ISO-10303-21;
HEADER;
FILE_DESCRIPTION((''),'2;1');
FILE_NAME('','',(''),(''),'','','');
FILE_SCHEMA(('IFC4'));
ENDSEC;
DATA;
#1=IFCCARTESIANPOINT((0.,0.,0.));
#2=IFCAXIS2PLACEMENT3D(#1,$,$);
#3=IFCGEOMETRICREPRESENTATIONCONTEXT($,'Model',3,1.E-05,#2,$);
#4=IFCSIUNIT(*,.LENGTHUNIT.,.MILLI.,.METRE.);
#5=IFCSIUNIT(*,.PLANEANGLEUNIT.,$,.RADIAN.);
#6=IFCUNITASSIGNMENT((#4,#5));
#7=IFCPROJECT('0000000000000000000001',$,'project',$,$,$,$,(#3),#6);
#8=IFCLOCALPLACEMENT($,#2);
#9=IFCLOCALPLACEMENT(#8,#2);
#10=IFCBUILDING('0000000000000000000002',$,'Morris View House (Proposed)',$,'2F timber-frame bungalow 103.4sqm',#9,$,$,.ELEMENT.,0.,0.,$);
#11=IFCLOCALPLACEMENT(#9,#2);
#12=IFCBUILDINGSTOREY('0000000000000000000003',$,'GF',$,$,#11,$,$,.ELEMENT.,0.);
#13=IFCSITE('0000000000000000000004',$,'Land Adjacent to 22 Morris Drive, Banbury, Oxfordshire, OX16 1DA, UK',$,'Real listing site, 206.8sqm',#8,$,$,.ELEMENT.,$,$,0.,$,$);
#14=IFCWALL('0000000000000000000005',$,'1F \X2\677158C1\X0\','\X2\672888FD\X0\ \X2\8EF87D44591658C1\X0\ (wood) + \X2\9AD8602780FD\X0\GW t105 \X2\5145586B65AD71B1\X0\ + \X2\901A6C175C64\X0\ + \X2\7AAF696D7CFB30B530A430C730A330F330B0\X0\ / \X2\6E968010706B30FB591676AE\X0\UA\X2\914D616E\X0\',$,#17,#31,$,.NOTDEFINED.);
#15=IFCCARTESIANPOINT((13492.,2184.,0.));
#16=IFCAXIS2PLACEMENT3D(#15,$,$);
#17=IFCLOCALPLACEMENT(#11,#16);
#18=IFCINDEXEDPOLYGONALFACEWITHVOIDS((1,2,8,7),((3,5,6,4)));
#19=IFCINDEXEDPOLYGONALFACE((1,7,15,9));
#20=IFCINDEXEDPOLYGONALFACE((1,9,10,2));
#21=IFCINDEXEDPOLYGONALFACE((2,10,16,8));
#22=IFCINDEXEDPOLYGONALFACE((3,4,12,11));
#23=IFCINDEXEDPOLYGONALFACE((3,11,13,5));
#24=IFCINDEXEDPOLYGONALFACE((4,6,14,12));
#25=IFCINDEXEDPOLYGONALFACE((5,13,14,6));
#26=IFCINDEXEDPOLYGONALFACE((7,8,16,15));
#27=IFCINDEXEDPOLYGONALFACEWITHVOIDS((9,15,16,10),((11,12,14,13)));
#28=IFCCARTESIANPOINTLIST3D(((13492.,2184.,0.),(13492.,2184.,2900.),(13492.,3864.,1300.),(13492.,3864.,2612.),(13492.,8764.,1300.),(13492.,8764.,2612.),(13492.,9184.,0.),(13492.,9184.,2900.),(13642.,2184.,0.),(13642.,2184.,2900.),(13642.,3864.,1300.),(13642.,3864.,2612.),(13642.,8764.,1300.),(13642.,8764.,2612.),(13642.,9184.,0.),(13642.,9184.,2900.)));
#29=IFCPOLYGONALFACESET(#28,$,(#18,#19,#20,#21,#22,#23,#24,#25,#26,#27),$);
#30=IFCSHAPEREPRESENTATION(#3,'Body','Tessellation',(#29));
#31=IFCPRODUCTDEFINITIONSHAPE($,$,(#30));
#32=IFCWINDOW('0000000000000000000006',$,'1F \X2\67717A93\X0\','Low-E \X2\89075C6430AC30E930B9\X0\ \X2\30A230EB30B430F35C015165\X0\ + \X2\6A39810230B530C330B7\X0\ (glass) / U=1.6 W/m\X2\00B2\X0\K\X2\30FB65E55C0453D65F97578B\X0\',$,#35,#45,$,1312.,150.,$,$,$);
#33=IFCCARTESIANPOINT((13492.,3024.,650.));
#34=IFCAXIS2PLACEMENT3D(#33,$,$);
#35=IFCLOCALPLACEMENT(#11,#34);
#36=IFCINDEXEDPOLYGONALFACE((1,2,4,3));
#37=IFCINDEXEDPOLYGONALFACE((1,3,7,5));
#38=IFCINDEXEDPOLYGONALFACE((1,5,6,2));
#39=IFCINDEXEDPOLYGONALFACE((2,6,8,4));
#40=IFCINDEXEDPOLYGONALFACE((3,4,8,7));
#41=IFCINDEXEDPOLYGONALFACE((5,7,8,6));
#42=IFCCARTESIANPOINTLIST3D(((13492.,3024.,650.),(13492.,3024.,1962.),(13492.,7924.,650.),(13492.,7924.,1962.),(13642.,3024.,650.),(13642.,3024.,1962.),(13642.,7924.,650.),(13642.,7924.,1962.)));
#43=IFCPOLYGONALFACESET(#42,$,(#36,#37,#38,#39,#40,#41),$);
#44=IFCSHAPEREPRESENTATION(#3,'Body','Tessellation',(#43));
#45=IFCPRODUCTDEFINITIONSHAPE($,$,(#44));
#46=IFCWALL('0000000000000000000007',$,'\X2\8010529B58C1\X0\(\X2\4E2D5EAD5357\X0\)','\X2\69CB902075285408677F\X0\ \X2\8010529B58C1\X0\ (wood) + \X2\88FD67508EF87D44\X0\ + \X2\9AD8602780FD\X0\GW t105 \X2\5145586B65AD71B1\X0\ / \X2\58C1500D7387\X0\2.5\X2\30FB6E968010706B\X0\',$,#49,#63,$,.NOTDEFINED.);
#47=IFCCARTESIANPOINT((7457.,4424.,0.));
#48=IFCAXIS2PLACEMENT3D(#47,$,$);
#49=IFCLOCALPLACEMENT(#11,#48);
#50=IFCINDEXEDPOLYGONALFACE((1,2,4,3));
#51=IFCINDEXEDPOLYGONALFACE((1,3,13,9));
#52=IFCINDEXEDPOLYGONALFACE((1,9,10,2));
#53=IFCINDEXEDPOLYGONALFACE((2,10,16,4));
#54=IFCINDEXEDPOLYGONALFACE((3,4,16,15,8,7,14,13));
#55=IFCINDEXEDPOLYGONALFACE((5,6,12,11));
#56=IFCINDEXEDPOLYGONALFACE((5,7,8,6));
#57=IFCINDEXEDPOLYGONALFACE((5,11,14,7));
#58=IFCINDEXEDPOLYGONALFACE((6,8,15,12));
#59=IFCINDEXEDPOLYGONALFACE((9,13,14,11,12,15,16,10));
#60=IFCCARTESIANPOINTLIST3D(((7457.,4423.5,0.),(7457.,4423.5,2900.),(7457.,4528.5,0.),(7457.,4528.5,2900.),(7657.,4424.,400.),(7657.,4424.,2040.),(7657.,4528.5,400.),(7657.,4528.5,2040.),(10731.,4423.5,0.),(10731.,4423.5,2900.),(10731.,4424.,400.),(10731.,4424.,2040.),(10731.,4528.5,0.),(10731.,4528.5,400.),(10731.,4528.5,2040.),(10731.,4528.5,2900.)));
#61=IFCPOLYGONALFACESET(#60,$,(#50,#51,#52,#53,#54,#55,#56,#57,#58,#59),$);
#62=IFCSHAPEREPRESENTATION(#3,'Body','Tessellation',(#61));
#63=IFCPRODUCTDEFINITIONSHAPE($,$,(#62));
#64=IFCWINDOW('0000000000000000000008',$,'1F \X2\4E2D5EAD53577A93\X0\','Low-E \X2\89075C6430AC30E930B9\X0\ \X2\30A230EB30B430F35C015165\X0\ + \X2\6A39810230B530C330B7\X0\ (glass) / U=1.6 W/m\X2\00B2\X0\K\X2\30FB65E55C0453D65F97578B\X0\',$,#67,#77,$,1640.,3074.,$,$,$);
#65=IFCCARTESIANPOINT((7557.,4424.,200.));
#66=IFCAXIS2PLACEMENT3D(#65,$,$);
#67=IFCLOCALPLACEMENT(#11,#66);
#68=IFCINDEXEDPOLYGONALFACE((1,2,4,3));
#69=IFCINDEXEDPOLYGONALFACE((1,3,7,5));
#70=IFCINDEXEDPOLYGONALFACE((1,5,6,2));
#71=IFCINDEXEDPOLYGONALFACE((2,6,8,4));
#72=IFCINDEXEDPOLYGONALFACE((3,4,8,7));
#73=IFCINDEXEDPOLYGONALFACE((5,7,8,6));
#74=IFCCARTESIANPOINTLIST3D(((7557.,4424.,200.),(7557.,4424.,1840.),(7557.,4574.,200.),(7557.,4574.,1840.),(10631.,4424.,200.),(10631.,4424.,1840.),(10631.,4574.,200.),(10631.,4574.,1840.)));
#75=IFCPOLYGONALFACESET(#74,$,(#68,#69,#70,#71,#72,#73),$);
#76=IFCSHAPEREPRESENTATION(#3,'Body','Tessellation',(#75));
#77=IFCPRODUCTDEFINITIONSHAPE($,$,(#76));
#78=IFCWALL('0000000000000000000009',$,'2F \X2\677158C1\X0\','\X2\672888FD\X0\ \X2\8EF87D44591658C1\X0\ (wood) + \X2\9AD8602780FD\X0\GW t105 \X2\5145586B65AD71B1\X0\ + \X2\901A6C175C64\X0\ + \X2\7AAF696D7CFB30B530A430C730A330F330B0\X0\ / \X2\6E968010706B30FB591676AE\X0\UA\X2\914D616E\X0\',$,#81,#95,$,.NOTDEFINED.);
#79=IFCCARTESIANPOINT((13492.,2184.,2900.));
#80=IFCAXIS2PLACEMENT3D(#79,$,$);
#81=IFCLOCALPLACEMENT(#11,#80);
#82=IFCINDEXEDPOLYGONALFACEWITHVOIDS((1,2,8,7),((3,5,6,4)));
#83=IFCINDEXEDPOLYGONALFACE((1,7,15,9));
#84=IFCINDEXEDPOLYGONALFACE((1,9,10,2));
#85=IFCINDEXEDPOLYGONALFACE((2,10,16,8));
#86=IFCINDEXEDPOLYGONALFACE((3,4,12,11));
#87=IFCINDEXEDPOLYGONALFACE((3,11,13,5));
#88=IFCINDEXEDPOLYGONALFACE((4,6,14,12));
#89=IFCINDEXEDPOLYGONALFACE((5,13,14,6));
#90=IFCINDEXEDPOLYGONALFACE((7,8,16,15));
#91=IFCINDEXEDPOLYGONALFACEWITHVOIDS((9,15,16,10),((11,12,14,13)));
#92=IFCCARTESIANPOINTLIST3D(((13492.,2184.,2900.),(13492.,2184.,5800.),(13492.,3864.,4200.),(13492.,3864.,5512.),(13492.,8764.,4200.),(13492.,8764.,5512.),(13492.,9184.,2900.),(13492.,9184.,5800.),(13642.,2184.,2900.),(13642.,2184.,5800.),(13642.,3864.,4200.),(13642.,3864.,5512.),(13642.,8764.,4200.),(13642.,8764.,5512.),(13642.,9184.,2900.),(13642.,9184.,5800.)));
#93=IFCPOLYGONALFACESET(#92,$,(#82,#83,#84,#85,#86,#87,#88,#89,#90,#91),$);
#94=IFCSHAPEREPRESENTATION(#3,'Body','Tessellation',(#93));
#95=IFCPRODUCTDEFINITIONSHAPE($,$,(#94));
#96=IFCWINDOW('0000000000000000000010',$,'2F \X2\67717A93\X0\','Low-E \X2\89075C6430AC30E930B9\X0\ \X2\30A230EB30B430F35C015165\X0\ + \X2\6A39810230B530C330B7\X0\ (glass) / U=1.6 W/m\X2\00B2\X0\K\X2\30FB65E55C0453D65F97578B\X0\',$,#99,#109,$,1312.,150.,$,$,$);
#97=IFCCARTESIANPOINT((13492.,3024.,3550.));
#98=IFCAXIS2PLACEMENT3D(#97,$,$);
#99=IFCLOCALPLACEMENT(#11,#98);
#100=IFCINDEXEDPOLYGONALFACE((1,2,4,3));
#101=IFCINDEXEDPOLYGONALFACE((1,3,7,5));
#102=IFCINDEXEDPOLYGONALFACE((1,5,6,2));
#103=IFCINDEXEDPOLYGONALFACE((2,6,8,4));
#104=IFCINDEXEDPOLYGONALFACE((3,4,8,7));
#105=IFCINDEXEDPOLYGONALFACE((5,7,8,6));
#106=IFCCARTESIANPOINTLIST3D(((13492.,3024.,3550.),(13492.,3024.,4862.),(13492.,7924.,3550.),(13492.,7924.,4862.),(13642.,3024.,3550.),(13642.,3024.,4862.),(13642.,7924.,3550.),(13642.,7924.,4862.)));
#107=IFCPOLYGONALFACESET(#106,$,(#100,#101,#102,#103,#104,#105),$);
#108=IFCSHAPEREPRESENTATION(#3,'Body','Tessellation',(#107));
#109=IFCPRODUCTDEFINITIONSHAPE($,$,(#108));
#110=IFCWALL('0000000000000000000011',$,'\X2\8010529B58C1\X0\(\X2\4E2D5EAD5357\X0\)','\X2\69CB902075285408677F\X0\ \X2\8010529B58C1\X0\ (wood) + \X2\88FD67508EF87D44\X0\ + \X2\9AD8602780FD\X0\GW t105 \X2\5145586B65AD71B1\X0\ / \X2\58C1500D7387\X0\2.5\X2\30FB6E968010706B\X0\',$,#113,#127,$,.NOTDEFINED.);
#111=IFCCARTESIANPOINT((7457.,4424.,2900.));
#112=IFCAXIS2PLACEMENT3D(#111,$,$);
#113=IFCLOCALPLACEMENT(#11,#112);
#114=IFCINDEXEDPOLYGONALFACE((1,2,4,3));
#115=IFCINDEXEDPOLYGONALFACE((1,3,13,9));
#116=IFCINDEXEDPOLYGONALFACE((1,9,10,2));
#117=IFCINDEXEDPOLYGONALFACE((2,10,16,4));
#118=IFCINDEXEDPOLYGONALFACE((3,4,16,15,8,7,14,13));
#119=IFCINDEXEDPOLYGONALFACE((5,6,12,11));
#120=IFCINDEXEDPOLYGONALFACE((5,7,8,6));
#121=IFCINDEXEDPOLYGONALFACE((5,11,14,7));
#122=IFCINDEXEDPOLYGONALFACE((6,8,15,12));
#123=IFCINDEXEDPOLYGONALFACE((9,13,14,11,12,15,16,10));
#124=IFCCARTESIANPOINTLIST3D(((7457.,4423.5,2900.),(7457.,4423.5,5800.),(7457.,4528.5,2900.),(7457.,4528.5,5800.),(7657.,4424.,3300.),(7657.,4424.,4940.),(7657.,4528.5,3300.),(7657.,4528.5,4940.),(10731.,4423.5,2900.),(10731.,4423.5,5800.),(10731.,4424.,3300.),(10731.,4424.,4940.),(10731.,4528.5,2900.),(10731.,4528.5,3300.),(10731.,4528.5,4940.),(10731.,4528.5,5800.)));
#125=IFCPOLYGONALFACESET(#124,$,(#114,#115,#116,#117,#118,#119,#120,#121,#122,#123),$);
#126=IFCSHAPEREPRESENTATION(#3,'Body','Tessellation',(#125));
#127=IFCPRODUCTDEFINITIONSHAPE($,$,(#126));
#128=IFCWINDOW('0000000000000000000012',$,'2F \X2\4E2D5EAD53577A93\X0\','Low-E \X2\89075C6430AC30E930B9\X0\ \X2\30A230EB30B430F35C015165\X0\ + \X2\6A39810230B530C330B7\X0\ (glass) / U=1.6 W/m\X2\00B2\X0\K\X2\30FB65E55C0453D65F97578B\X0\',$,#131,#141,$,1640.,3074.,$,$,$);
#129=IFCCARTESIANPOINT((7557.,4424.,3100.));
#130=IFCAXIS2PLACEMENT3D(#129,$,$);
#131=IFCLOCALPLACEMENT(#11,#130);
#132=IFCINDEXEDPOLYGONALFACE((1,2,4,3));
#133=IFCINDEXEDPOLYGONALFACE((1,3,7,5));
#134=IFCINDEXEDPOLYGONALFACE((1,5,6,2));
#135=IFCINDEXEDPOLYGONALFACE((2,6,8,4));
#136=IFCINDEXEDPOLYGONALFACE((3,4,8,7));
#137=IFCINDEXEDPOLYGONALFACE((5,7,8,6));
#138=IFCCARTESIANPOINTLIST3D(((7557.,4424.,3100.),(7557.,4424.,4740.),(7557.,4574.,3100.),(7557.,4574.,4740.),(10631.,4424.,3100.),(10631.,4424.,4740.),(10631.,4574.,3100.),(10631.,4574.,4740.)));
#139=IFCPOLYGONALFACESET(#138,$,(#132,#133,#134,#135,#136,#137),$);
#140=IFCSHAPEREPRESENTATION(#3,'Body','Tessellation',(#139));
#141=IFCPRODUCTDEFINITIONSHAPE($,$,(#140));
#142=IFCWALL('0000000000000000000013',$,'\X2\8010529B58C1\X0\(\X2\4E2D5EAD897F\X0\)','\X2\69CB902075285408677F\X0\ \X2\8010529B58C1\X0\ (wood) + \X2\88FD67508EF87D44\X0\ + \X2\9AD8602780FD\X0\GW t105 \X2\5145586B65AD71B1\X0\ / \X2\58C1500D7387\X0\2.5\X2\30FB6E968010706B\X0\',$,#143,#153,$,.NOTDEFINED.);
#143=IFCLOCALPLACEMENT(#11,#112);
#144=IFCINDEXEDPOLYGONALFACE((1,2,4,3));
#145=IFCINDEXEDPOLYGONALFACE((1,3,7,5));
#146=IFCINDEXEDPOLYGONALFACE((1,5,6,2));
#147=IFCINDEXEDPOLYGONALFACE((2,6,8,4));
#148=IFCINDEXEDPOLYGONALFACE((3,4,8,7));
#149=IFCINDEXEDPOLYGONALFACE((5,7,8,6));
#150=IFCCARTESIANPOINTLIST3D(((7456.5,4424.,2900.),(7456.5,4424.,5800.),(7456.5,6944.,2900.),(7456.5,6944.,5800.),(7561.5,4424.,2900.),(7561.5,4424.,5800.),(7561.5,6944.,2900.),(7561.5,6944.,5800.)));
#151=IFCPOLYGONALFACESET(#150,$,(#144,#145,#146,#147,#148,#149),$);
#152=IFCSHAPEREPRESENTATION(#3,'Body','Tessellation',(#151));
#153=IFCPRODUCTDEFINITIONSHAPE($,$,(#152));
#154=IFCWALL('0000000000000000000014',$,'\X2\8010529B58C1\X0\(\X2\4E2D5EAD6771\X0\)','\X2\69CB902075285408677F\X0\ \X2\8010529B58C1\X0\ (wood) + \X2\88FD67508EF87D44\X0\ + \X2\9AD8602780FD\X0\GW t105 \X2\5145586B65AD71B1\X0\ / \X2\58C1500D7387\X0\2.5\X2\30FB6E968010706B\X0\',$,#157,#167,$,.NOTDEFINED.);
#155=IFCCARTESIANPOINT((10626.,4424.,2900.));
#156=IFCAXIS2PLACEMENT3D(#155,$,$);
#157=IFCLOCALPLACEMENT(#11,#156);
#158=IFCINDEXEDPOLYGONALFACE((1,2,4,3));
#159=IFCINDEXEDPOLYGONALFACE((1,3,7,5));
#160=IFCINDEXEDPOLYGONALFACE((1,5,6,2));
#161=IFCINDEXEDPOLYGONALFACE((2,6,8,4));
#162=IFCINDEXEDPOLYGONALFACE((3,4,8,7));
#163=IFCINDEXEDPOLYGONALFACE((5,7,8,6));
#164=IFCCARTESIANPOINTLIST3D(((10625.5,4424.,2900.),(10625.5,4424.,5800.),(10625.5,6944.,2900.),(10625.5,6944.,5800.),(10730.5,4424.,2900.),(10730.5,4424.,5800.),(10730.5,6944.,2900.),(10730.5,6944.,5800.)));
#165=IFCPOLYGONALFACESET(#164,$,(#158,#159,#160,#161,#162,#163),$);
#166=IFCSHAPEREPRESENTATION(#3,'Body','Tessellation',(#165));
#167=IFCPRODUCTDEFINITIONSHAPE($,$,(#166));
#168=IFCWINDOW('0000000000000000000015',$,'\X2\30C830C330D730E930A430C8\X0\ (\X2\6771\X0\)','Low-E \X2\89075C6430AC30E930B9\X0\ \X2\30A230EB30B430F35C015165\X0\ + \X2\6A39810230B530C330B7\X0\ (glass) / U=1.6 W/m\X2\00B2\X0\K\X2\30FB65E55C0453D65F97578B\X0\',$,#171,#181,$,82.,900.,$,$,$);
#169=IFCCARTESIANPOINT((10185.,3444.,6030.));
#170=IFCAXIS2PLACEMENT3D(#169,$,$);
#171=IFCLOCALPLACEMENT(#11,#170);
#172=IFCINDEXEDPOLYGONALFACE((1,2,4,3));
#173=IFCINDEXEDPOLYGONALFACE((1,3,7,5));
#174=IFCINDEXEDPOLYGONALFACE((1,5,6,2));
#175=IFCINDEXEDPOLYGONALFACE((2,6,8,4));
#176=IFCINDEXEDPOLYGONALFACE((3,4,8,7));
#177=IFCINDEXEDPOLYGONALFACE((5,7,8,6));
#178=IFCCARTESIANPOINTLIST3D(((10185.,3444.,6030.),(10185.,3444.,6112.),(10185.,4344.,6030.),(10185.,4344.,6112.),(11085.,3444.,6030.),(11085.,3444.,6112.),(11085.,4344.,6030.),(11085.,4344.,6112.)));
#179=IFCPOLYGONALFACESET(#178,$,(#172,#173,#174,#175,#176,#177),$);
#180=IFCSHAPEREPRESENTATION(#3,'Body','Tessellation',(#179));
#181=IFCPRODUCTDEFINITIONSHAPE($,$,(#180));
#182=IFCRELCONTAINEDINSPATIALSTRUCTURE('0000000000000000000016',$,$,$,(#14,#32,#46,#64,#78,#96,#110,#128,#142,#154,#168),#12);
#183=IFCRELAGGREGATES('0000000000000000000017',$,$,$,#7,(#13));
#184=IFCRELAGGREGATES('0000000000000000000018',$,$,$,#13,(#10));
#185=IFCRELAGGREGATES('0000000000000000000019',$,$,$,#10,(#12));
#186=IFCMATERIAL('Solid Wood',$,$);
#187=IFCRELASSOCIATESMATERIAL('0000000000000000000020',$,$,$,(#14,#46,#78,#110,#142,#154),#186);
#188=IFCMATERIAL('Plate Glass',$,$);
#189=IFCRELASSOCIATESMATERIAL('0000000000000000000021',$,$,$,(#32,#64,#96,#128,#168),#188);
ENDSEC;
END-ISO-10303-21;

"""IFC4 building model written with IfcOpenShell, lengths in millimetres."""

from ifc_helpers import new_model, si_unit, frame, frame_2d, origin, place, context, project, spatial, rectangle, extrude, material, element, fill, save


model = new_model("IFC4")

# Units and contexts
model_context = context("Model", 3, precision=1e-05, world=origin())
ifc_project = project(units=[si_unit("LENGTHUNIT", "METRE", prefix="MILLI"), si_unit("PLANEANGLEUNIT", "RADIAN")], contexts=[model_context])

# Site, building, storey
site_placement = place(None, origin())
site = spatial("IfcSite", under=ifc_project, at=site_placement, Name="Land Adjacent to 22 Morris Drive, Banbury, Oxfordshire, OX16 1DA, UK", ObjectType="Real listing site, 206.8sqm", CompositionType="ELEMENT", RefElevation=0.0)
building_placement = place(site_placement, origin())
building = spatial("IfcBuilding", under=site, at=building_placement, Name="Morris View House (Proposed)", ObjectType="2F timber-frame bungalow 103.4sqm", CompositionType="ELEMENT", ElevationOfRefHeight=0.0, ElevationOfTerrain=0.0)
storey_placement = place(building_placement, origin())
storey = spatial("IfcBuildingStorey", under=building, at=storey_placement, Name="GF", CompositionType="ELEMENT", Elevation=0.0)

# Shared definitions
ifc_material_1 = material(Name="Solid Wood")

# Walls, openings, windows
wall_1_placement = place(storey_placement, frame((13492.0, 2184.0, 0.0)))
wall_1 = element("IfcWall", 1, at=wall_1_placement, inside=storey, material=ifc_material_1, Name="1F 東壁", Description="木製 軸組外壁 (wood) + 高性能GW t105 充填断熱 + 通気層 + 窯業系サイディング / 準耐火・外皮UA配慮", PredefinedType="NOTDEFINED", context=model_context, shape_type="SweptSolid", body=[
    extrude(rectangle(XDim=150.0, YDim=7000.0, at=frame_2d((75.0, 3500.0))), frame((13492.0, 2184.0, 0.0)), (0.0, 0.0, 1.0), 2900.0),
])
opening_1_placement = place(storey_placement, frame((13492.0, 3024.0, 650.0)))
opening_1 = element("IfcOpeningElement", 2, at=opening_1_placement, cuts=wall_1, PredefinedType="NOTDEFINED", context=model_context, shape_type="SweptSolid", body=[
    extrude(rectangle(XDim=150.0, YDim=4900.0, at=frame_2d((75.0, 2450.0))), frame((13492.0, 3024.0, 650.0)), (0.0, 0.0, 1.0), 1312.0),
])
ifc_material_2 = material(Name="Plate Glass")
window_1_placement = place(storey_placement, frame((13492.0, 3024.0, 650.0)))
window_1 = element("IfcWindow", 3, at=window_1_placement, inside=storey, material=ifc_material_2, Name="1F 東窓", Description="Low-E 複層ガラス アルゴン封入 + 樹脂サッシ (glass) / U=1.6 W/m²K・日射取得型", OverallHeight=1312.0, OverallWidth=150.0, context=model_context, shape_type="SweptSolid", body=[
    extrude(rectangle(XDim=150.0, YDim=4900.0, at=frame_2d((75.0, 2450.0))), frame((13492.0, 3024.0, 650.0)), (0.0, 0.0, 1.0), 1312.0),
])
fill(opening_1, window_1)
wall_2_placement = place(storey_placement, frame((7457.0, 4424.0, 0.0)))
wall_2 = element("IfcWall", 4, at=wall_2_placement, inside=storey, material=ifc_material_1, Name="耐力壁(中庭南)", Description="構造用合板 耐力壁 (wood) + 製材軸組 + 高性能GW t105 充填断熱 / 壁倍率2.5・準耐火", PredefinedType="NOTDEFINED", context=model_context, shape_type="SweptSolid", body=[
    extrude(rectangle(XDim=3274.0, YDim=105.0, at=frame_2d((1637.0, 52.0))), frame((7457.0, 4424.0, 0.0)), (0.0, 0.0, 1.0), 2900.0),
])
opening_2_placement = place(storey_placement, frame((7557.0, 4424.0, 200.0)))
opening_2 = element("IfcOpeningElement", 5, at=opening_2_placement, cuts=wall_2, PredefinedType="NOTDEFINED", context=model_context, shape_type="SweptSolid", body=[
    extrude(rectangle(XDim=3074.0, YDim=150.0, at=frame_2d((1537.0, 75.0))), frame((7557.0, 4424.0, 200.0)), (0.0, 0.0, 1.0), 1640.0),
])
window_2_placement = place(storey_placement, frame((7557.0, 4424.0, 200.0)))
window_2 = element("IfcWindow", 6, at=window_2_placement, inside=storey, material=ifc_material_2, Name="1F 中庭南窓", Description="Low-E 複層ガラス アルゴン封入 + 樹脂サッシ (glass) / U=1.6 W/m²K・日射取得型", OverallHeight=1640.0, OverallWidth=3074.0, context=model_context, shape_type="SweptSolid", body=[
    extrude(rectangle(XDim=3074.0, YDim=150.0, at=frame_2d((1537.0, 75.0))), frame((7557.0, 4424.0, 200.0)), (0.0, 0.0, 1.0), 1640.0),
])
fill(opening_2, window_2)

# Walls, openings, windows
wall_3_placement = place(storey_placement, frame((13492.0, 2184.0, 2900.0)))
wall_3 = element("IfcWall", 7, at=wall_3_placement, inside=storey, material=ifc_material_1, Name="2F 東壁", Description="木製 軸組外壁 (wood) + 高性能GW t105 充填断熱 + 通気層 + 窯業系サイディング / 準耐火・外皮UA配慮", PredefinedType="NOTDEFINED", context=model_context, shape_type="SweptSolid", body=[
    extrude(rectangle(XDim=150.0, YDim=7000.0, at=frame_2d((75.0, 3500.0))), frame((13492.0, 2184.0, 2900.0)), (0.0, 0.0, 1.0), 2900.0),
])
opening_3_placement = place(storey_placement, frame((13492.0, 3024.0, 3550.0)))
opening_3 = element("IfcOpeningElement", 8, at=opening_3_placement, cuts=wall_3, PredefinedType="NOTDEFINED", context=model_context, shape_type="SweptSolid", body=[
    extrude(rectangle(XDim=150.0, YDim=4900.0, at=frame_2d((75.0, 2450.0))), frame((13492.0, 3024.0, 3550.0)), (0.0, 0.0, 1.0), 1312.0),
])
window_3_placement = place(storey_placement, frame((13492.0, 3024.0, 3550.0)))
window_3 = element("IfcWindow", 9, at=window_3_placement, inside=storey, material=ifc_material_2, Name="2F 東窓", Description="Low-E 複層ガラス アルゴン封入 + 樹脂サッシ (glass) / U=1.6 W/m²K・日射取得型", OverallHeight=1312.0, OverallWidth=150.0, context=model_context, shape_type="SweptSolid", body=[
    extrude(rectangle(XDim=150.0, YDim=4900.0, at=frame_2d((75.0, 2450.0))), frame((13492.0, 3024.0, 3550.0)), (0.0, 0.0, 1.0), 1312.0),
])
fill(opening_3, window_3)
wall_4_placement = place(storey_placement, frame((7457.0, 4424.0, 2900.0)))
wall_4 = element("IfcWall", 10, at=wall_4_placement, inside=storey, material=ifc_material_1, Name="耐力壁(中庭南)", Description="構造用合板 耐力壁 (wood) + 製材軸組 + 高性能GW t105 充填断熱 / 壁倍率2.5・準耐火", PredefinedType="NOTDEFINED", context=model_context, shape_type="SweptSolid", body=[
    extrude(rectangle(XDim=3274.0, YDim=105.0, at=frame_2d((1637.0, 52.0))), frame((7457.0, 4424.0, 2900.0)), (0.0, 0.0, 1.0), 2900.0),
])
opening_4_placement = place(storey_placement, frame((7557.0, 4424.0, 3100.0)))
opening_4 = element("IfcOpeningElement", 11, at=opening_4_placement, cuts=wall_4, PredefinedType="NOTDEFINED", context=model_context, shape_type="SweptSolid", body=[
    extrude(rectangle(XDim=3074.0, YDim=150.0, at=frame_2d((1537.0, 75.0))), frame((7557.0, 4424.0, 3100.0)), (0.0, 0.0, 1.0), 1640.0),
])
window_4_placement = place(storey_placement, frame((7557.0, 4424.0, 3100.0)))
window_4 = element("IfcWindow", 12, at=window_4_placement, inside=storey, material=ifc_material_2, Name="2F 中庭南窓", Description="Low-E 複層ガラス アルゴン封入 + 樹脂サッシ (glass) / U=1.6 W/m²K・日射取得型", OverallHeight=1640.0, OverallWidth=3074.0, context=model_context, shape_type="SweptSolid", body=[
    extrude(rectangle(XDim=3074.0, YDim=150.0, at=frame_2d((1537.0, 75.0))), frame((7557.0, 4424.0, 3100.0)), (0.0, 0.0, 1.0), 1640.0),
])
fill(opening_4, window_4)

# Walls
wall_5_placement = place(storey_placement, frame((7457.0, 4424.0, 2900.0)))
element("IfcWall", 13, at=wall_5_placement, inside=storey, material=ifc_material_1, Name="耐力壁(中庭西)", Description="構造用合板 耐力壁 (wood) + 製材軸組 + 高性能GW t105 充填断熱 / 壁倍率2.5・準耐火", PredefinedType="NOTDEFINED", context=model_context, shape_type="SweptSolid", body=[
    extrude(rectangle(XDim=105.0, YDim=2520.0, at=frame_2d((52.0, 1260.0))), frame((7457.0, 4424.0, 2900.0)), (0.0, 0.0, 1.0), 2900.0),
])
wall_6_placement = place(storey_placement, frame((10626.0, 4424.0, 2900.0)))
element("IfcWall", 14, at=wall_6_placement, inside=storey, material=ifc_material_1, Name="耐力壁(中庭東)", Description="構造用合板 耐力壁 (wood) + 製材軸組 + 高性能GW t105 充填断熱 / 壁倍率2.5・準耐火", PredefinedType="NOTDEFINED", context=model_context, shape_type="SweptSolid", body=[
    extrude(rectangle(XDim=105.0, YDim=2520.0, at=frame_2d((52.0, 1260.0))), frame((10626.0, 4424.0, 2900.0)), (0.0, 0.0, 1.0), 2900.0),
])

# Window
window_5_placement = place(storey_placement, frame((10185.0, 3444.0, 6030.0)))
element("IfcWindow", 15, at=window_5_placement, inside=storey, material=ifc_material_2, Name="トップライト (東)", Description="Low-E 複層ガラス アルゴン封入 + 樹脂サッシ (glass) / U=1.6 W/m²K・日射取得型", OverallHeight=82.0, OverallWidth=900.0, context=model_context, shape_type="SweptSolid", body=[
    extrude(rectangle(XDim=900.0, YDim=900.0, at=frame_2d((450.0, 450.0))), frame((10185.0, 3444.0, 6030.0)), (0.0, 0.0, 1.0), 82.0),
])

save(model, "model.ifc")
